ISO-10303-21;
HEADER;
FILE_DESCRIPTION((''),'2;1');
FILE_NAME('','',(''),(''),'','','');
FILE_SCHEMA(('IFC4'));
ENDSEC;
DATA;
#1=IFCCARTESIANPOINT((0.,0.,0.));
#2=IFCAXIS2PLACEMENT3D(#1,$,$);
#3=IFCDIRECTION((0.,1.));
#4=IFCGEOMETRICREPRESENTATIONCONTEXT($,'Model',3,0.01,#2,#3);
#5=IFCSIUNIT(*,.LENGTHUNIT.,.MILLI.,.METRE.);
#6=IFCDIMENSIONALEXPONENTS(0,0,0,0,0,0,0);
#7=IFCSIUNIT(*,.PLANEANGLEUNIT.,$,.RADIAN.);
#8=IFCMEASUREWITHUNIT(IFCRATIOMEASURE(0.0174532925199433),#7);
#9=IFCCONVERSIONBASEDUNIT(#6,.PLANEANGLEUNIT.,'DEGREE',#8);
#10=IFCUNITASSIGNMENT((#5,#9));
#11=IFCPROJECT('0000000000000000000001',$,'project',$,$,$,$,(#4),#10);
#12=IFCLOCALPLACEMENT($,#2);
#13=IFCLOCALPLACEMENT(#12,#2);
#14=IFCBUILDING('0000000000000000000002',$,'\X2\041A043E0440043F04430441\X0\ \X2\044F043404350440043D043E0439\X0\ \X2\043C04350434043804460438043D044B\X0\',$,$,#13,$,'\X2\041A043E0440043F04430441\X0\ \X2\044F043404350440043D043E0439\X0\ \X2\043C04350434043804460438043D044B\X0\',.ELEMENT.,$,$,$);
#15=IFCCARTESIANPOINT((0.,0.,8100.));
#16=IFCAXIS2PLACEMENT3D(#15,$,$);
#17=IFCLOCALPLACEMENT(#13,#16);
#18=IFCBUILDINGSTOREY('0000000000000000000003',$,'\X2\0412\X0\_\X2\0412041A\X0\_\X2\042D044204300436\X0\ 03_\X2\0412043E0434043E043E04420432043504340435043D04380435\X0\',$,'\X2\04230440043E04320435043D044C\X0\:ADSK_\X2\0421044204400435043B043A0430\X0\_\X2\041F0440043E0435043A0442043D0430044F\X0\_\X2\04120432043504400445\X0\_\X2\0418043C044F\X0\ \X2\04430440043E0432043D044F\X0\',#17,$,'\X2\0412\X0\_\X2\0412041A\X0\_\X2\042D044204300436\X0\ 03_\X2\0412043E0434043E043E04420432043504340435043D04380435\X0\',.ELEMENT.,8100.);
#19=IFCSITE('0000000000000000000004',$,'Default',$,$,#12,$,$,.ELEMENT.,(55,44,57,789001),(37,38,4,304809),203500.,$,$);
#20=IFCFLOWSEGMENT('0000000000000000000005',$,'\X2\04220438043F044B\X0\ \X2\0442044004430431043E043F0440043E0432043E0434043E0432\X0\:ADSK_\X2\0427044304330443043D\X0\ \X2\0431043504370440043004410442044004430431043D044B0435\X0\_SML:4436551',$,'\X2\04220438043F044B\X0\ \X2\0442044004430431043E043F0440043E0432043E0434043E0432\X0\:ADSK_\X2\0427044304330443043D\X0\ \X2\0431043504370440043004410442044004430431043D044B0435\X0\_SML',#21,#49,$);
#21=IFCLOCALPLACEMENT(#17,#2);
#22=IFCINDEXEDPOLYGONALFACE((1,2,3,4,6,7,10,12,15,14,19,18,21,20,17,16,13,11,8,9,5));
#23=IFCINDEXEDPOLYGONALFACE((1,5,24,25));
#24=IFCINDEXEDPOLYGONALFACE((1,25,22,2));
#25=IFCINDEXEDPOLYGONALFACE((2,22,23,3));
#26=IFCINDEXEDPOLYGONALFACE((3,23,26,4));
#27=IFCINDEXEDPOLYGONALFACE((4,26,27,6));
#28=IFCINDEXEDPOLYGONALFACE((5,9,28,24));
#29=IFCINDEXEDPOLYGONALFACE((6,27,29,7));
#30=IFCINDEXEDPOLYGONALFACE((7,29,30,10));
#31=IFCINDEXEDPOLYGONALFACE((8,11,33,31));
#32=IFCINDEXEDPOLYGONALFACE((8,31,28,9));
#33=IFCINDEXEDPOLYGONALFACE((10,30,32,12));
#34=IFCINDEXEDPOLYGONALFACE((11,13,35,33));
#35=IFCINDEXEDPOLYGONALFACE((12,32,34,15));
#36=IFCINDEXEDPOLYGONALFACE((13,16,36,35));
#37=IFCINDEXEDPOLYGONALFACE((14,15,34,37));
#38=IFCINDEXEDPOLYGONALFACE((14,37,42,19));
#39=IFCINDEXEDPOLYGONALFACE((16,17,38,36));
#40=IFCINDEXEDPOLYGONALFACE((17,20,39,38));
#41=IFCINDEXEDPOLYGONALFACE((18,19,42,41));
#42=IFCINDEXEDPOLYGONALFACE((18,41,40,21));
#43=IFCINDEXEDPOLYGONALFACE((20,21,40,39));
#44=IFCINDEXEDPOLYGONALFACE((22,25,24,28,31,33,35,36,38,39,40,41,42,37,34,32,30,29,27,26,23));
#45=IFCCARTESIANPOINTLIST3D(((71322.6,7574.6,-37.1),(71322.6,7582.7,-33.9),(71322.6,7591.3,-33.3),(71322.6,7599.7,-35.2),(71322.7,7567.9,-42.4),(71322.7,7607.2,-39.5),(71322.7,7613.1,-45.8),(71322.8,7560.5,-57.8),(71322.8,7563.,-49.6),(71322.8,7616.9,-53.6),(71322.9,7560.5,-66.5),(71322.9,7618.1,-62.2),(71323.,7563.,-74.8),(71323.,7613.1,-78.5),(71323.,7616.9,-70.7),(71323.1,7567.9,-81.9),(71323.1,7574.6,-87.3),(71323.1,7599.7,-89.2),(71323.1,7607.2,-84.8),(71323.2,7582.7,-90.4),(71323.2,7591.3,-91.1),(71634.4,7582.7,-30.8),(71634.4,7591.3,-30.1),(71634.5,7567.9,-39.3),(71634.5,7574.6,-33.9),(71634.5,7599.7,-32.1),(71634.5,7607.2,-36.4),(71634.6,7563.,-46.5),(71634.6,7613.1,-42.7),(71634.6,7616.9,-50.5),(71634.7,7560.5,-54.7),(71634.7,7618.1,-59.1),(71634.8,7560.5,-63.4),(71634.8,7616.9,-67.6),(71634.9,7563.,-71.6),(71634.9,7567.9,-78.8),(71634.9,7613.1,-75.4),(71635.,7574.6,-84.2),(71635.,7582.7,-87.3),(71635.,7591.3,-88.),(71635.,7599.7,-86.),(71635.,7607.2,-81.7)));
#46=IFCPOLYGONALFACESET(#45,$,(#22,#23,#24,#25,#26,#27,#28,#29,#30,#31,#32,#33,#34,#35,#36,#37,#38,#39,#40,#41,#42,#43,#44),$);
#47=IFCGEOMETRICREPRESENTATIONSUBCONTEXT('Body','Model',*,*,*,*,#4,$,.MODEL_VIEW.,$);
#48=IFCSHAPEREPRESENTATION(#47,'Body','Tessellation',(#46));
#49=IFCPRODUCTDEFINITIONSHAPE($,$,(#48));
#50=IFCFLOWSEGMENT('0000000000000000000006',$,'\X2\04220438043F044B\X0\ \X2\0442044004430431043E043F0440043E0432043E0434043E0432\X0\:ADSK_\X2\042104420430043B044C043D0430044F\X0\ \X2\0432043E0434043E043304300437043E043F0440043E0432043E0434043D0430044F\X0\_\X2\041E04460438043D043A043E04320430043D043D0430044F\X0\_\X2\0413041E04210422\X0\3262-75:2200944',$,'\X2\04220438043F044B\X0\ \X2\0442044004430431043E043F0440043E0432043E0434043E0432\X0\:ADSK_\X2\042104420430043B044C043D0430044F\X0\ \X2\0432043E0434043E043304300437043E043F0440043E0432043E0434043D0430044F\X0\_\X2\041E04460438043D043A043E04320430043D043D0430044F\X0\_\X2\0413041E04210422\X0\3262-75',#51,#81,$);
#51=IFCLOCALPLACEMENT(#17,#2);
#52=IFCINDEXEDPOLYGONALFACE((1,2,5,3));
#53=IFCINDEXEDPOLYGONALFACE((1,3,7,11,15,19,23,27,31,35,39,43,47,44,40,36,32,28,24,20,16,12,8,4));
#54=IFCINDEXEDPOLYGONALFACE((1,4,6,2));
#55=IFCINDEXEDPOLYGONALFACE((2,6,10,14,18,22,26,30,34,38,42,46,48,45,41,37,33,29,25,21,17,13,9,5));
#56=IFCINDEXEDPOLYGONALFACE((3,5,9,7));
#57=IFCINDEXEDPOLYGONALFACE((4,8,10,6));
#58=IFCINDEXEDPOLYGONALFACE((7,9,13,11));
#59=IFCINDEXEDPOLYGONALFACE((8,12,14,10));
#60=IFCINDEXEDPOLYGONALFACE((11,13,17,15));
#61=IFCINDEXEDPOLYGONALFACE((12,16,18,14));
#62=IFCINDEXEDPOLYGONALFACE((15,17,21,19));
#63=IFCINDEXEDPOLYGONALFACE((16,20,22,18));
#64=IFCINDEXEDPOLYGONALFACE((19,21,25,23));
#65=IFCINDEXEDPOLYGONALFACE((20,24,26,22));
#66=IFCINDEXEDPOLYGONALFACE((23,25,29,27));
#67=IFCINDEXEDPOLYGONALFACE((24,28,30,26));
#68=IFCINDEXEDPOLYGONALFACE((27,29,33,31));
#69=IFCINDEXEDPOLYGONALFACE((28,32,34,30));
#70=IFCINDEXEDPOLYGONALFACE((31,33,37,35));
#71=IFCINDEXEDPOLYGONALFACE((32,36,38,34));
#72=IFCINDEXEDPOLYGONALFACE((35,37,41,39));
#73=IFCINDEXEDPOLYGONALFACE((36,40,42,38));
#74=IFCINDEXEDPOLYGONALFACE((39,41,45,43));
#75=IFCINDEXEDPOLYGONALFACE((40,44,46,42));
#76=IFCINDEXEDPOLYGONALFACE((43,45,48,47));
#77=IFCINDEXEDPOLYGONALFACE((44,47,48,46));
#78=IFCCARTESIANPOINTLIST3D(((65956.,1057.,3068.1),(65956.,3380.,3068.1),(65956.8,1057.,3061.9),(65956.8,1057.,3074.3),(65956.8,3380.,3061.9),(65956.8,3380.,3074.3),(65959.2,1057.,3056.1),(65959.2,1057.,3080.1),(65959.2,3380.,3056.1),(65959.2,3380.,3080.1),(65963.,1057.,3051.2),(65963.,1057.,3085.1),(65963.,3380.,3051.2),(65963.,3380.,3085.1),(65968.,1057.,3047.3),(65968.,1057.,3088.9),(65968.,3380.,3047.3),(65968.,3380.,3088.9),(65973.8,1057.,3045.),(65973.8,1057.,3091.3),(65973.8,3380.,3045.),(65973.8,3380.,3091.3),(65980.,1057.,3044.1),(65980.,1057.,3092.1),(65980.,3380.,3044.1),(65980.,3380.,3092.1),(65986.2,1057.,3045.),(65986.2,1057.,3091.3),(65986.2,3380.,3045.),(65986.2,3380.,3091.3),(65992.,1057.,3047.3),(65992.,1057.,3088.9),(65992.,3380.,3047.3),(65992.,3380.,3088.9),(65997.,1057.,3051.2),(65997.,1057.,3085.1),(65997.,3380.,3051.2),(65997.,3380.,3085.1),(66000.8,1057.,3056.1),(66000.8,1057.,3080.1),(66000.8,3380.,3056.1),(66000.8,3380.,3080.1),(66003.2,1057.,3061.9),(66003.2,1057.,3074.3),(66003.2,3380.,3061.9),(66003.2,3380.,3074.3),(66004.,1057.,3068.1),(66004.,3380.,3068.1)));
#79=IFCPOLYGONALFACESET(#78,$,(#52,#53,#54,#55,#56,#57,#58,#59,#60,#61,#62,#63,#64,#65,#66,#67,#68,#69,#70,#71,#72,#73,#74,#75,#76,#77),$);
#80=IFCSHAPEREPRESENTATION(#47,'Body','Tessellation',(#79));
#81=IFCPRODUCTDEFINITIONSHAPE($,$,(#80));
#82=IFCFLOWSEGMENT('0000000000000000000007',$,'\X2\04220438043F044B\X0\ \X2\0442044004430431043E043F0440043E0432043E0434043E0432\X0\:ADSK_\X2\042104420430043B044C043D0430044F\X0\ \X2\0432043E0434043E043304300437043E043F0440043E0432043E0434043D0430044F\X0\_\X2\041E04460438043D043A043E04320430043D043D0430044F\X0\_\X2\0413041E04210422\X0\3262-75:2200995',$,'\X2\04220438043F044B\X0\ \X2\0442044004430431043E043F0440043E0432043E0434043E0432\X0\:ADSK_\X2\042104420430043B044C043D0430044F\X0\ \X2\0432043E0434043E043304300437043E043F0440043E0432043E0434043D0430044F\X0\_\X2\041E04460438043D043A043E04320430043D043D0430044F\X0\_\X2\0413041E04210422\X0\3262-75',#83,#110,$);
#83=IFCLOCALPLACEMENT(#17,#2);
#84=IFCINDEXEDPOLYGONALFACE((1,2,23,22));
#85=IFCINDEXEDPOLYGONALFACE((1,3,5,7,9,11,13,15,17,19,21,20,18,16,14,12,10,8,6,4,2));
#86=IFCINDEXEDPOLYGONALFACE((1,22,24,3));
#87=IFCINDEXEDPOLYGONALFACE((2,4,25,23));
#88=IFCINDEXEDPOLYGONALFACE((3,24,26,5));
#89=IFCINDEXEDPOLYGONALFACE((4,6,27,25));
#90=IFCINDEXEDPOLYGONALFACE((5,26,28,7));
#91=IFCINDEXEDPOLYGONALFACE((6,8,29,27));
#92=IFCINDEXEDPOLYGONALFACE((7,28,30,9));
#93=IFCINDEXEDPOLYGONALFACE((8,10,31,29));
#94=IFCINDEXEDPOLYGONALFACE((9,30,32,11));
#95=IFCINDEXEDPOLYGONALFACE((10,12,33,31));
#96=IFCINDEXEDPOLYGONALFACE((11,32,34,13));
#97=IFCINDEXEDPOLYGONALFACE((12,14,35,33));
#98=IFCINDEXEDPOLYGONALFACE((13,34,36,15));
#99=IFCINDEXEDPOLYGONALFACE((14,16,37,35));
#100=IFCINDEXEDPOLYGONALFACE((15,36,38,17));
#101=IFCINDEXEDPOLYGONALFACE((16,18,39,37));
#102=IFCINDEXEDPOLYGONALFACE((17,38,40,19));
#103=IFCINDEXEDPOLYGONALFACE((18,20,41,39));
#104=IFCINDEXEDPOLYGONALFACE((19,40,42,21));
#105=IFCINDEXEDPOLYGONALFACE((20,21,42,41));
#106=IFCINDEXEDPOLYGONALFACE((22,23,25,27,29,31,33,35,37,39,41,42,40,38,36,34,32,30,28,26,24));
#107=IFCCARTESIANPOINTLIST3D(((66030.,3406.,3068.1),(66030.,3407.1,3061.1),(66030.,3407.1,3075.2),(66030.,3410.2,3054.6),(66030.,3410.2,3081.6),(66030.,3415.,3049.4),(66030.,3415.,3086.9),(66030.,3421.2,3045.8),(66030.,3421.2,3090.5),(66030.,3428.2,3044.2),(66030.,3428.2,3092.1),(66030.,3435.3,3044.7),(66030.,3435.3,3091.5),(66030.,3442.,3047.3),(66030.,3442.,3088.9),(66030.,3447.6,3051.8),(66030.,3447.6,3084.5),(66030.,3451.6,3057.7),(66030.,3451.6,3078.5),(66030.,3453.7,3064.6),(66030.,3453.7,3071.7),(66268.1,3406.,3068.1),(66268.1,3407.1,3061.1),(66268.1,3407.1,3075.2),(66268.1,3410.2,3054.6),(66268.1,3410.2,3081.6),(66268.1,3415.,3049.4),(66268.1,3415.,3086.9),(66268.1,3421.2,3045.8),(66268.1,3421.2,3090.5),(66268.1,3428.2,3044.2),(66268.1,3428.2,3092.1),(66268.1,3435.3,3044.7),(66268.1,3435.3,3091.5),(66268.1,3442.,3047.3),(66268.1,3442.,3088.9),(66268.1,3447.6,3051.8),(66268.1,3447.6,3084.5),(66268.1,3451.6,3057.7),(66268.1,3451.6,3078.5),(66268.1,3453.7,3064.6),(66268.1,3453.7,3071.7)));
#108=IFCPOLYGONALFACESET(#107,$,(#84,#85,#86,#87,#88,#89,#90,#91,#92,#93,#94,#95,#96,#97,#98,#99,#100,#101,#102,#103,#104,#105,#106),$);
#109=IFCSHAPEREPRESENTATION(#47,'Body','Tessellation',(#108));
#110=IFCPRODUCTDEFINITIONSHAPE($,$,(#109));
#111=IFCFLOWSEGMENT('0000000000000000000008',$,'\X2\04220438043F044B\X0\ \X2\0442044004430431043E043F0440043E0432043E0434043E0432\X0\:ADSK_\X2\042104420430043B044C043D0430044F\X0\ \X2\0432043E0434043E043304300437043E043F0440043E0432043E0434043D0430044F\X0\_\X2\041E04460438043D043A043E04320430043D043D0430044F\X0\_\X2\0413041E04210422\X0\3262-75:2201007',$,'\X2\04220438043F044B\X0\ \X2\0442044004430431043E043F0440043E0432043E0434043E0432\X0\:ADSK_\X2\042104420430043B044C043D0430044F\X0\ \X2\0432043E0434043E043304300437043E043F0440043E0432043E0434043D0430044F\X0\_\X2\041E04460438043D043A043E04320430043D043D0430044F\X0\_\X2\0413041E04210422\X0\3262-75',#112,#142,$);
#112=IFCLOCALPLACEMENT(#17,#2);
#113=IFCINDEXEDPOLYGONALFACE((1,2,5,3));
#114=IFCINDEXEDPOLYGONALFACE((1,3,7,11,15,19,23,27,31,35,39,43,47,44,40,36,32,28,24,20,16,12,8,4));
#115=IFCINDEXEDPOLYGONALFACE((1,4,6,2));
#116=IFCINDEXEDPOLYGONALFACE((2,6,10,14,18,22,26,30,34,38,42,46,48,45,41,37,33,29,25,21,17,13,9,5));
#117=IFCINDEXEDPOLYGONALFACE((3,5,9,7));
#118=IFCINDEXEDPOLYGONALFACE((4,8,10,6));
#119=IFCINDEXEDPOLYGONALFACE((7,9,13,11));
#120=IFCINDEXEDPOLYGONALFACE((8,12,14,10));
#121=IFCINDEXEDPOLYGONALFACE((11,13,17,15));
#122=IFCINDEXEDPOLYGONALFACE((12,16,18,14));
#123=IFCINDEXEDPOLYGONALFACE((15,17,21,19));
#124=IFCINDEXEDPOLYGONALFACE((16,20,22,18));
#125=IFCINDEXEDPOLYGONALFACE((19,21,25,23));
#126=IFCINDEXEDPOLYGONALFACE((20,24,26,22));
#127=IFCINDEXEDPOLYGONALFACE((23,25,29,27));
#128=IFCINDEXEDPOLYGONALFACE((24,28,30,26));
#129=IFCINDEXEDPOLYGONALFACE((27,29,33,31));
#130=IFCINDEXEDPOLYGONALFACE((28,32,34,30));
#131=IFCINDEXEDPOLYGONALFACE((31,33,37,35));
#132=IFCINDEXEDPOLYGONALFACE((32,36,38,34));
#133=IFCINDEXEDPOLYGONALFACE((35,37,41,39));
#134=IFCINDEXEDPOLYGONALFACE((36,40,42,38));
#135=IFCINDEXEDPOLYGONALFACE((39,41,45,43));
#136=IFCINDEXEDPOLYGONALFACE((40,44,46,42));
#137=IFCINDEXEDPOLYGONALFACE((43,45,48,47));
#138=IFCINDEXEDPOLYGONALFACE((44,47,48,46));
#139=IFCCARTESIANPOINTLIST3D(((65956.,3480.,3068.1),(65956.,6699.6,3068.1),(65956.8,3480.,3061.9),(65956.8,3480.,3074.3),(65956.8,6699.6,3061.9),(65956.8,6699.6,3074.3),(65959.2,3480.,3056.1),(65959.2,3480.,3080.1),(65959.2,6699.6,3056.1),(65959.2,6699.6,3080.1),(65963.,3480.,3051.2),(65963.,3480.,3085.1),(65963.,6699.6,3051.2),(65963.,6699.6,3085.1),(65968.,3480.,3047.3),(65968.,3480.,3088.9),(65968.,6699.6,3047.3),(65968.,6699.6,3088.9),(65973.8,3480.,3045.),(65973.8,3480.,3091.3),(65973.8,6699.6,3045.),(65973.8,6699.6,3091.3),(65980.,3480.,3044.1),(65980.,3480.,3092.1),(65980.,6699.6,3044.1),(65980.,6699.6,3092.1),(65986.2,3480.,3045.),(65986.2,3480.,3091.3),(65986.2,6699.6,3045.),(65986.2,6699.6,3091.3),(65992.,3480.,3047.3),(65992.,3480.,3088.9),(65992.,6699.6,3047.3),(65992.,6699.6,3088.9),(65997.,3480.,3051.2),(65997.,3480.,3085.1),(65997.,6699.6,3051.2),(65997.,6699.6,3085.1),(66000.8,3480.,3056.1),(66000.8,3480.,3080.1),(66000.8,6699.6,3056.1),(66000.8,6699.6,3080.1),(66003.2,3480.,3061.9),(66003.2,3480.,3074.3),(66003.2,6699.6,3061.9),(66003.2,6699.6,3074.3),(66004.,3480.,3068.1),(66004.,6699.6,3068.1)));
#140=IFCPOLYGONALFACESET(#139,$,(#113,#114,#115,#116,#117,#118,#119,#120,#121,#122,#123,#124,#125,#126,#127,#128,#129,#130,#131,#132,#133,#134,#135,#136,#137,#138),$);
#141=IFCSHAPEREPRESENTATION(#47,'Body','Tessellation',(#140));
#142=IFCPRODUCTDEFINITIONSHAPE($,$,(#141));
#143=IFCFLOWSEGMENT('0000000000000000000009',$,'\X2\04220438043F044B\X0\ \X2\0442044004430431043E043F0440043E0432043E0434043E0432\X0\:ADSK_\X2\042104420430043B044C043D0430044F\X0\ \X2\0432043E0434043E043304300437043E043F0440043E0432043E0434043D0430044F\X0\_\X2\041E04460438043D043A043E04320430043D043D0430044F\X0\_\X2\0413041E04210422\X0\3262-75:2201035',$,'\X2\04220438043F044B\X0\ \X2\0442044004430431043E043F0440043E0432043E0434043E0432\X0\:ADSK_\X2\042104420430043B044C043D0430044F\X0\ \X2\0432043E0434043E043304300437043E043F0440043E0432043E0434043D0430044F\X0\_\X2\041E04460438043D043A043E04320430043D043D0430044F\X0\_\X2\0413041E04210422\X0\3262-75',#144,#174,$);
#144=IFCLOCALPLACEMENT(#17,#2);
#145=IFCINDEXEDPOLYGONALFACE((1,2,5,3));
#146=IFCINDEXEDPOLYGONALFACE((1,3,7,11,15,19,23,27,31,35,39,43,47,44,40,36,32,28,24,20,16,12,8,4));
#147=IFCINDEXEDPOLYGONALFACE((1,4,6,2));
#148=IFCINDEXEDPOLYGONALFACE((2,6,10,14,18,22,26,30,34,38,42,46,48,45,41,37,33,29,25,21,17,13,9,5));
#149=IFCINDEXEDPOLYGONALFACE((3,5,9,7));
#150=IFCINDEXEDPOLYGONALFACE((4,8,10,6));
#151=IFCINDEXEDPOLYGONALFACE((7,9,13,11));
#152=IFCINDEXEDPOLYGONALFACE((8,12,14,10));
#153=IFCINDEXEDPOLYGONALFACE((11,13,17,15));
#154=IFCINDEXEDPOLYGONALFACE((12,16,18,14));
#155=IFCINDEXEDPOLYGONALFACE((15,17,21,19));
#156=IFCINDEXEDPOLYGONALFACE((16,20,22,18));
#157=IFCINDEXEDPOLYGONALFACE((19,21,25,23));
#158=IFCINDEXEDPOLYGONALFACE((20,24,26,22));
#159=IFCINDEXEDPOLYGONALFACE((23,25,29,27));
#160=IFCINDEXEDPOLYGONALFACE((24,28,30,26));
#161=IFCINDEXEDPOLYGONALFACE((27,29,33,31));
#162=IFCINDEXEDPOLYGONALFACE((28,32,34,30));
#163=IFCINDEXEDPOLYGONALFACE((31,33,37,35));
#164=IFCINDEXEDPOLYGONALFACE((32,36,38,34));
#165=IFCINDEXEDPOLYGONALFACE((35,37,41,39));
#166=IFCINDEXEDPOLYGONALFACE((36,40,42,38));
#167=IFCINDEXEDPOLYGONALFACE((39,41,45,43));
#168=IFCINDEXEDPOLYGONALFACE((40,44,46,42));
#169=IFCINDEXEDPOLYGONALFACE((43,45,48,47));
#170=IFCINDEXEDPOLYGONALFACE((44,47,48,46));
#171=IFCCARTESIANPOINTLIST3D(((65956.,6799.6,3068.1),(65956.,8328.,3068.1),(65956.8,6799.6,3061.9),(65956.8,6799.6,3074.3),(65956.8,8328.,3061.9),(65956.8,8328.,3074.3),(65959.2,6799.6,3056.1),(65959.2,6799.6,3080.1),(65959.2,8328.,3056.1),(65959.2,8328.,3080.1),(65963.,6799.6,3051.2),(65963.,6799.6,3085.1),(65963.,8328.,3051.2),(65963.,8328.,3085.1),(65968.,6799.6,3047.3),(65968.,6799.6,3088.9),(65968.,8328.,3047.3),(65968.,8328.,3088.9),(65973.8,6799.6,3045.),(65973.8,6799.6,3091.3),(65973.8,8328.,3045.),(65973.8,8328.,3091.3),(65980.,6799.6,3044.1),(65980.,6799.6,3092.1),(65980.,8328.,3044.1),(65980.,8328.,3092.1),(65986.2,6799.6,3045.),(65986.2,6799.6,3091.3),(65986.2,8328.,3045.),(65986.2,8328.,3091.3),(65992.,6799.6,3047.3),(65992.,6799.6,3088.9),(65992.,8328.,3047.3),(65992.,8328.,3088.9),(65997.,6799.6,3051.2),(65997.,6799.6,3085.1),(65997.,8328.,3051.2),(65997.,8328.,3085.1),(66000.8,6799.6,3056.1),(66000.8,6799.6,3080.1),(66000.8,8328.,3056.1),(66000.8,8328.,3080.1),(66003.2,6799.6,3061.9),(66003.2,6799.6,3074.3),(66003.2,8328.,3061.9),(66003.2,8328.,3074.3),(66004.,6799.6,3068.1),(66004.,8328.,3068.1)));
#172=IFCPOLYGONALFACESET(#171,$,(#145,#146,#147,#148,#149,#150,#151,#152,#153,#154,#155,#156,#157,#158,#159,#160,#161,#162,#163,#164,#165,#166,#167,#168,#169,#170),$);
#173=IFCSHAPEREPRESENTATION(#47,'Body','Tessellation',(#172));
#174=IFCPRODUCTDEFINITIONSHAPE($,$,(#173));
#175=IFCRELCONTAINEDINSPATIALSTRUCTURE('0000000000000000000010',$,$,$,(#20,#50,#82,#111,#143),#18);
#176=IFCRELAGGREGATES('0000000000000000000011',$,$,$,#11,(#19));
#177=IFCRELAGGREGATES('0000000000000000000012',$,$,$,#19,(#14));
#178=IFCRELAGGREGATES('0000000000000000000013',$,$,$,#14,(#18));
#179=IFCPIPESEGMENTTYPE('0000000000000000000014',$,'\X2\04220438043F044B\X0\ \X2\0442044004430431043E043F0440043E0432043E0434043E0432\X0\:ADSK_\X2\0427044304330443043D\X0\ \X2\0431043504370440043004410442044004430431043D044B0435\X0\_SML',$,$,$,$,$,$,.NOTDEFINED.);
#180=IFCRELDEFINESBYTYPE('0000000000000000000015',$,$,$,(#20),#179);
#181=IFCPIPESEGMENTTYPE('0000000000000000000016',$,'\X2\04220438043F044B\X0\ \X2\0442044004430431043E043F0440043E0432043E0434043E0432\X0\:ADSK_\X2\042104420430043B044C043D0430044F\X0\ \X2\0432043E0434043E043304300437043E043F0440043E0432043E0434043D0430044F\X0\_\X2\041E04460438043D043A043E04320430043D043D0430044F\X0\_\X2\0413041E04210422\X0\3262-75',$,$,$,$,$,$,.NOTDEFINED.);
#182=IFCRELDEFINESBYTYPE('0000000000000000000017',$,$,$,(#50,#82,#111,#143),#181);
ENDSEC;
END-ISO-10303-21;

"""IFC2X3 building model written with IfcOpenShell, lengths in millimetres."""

from ifc_helpers import new_model, entity, si_unit, converted_unit, direction, frame, origin, origin_2d_with_axis, place, context, subcontext, project, spatial, polyline, circle, outline, extrude, type_object, element, save


model = new_model("IFC2X3")

# Units and contexts
model_context = context("Model", 3, precision=0.01, world=origin(), true_north=direction((0.0, 1.0)))
body_context = subcontext(model_context, "Body", "Model", "MODEL_VIEW")
ifc_project = project(units=[si_unit("LENGTHUNIT", "METRE", prefix="MILLI"), converted_unit("PLANEANGLEUNIT", "DEGREE", entity("IfcRatioMeasure", 0.0174532925199433), si_unit("PLANEANGLEUNIT", "RADIAN"), dimensions=[0, 0, 0, 0, 0, 0, 0])], contexts=[model_context])

# Site, building, storey
site_placement = place(None, origin())
site = spatial("IfcSite", under=ifc_project, at=site_placement, Name="Default", CompositionType="ELEMENT", RefLatitude=(55, 44, 57, 789001), RefLongitude=(37, 38, 4, 304809), RefElevation=203500.0)
building_placement = place(site_placement, origin())
building = spatial("IfcBuilding", under=site, at=building_placement, Name="Корпус ядерной медицины", LongName="Корпус ядерной медицины", CompositionType="ELEMENT")
storey_placement = place(building_placement, frame((0.0, 0.0, 8100.0)))
storey = spatial("IfcBuildingStorey", under=building, at=storey_placement, Name="В_ВК_Этаж 03_Водоотведение", ObjectType="Уровень:ADSK_Стрелка_Проектная_Вверх_Имя уровня", LongName="В_ВК_Этаж 03_Водоотведение", CompositionType="ELEMENT", Elevation=8100.0)

# Flow segments
pipe_segment_type_1 = type_object("IfcPipeSegmentType", Name="Типы трубопроводов:ADSK_Чугун безраструбные_SML", PredefinedType="NOTDEFINED")
flow_segment_1_placement = place(storey_placement, frame((71321.0, 7558.5, -92.8)))
element("IfcFlowSegment", 1, at=flow_segment_1_placement, inside=storey, type_object=pipe_segment_type_1, Name="Типы трубопроводов:ADSK_Чугун безраструбные_SML:4436551", ObjectType="Типы трубопроводов:ADSK_Чугун безраструбные_SML", context=body_context, shape_type="SweptSolid", body=[
    extrude(circle(Radius=29.0, at=origin_2d_with_axis()), frame((1.9, 30.6, 30.6), z_axis=(0.99995, 0.000005, 0.01), x_axis=(-0.000005, 1.0, 0.0)), (0.0, 0.0, 1.0), 311.9),
])
pipe_segment_type_2 = type_object("IfcPipeSegmentType", Name="Типы трубопроводов:ADSK_Стальная водогазопроводная_Оцинкованная_ГОСТ3262-75", PredefinedType="NOTDEFINED")
flow_segment_2_placement = place(storey_placement, frame((65954.4, 1057.0, 3042.5)))
element("IfcFlowSegment", 2, at=flow_segment_2_placement, inside=storey, type_object=pipe_segment_type_2, Name="Типы трубопроводов:ADSK_Стальная водогазопроводная_Оцинкованная_ГОСТ3262-75:2200944", ObjectType="Типы трубопроводов:ADSK_Стальная водогазопроводная_Оцинкованная_ГОСТ3262-75", context=body_context, shape_type="SweptSolid", body=[
    extrude(outline(polyline([(-3.1, -23.8), (3.1, -23.8), (9.2, -22.2), (14.6, -19.0), (19.0, -14.6), (22.2, -9.2), (23.8, -3.1), (23.8, 3.1), (22.2, 9.2), (19.0, 14.6), (14.6, 19.0), (9.2, 22.2), (3.1, 23.8), (-3.1, 23.8), (-9.2, 22.2), (-14.6, 19.0), (-19.0, 14.6), (-22.2, 9.2), (-23.8, 3.1), (-23.8, -3.1), (-22.2, -9.2), (-19.0, -14.6), (-14.6, -19.0), (-9.2, -22.2), (-3.1, -23.8)])), frame((25.6, 0.0, 25.6), z_axis=(0.0, 1.0, 0.0), x_axis=(0.130526, 0.0, 0.991445)), (0.0, 0.0, 1.0), 2323.0),
])
flow_segment_3_placement = place(storey_placement, frame((66030.0, 3404.4, 3042.5)))
element("IfcFlowSegment", 3, at=flow_segment_3_placement, inside=storey, type_object=pipe_segment_type_2, Name="Типы трубопроводов:ADSK_Стальная водогазопроводная_Оцинкованная_ГОСТ3262-75:2200995", ObjectType="Типы трубопроводов:ADSK_Стальная водогазопроводная_Оцинкованная_ГОСТ3262-75", context=body_context, shape_type="SweptSolid", body=[
    extrude(circle(Radius=24.0, at=origin_2d_with_axis()), frame((0.0, 25.6, 25.6), z_axis=(1.0, 0.000003, 0.0), x_axis=(0.000003, -1.0, 0.0)), (0.0, 0.0, 1.0), 238.1),
])
flow_segment_4_placement = place(storey_placement, frame((65954.4, 3480.0, 3042.5)))
element("IfcFlowSegment", 4, at=flow_segment_4_placement, inside=storey, type_object=pipe_segment_type_2, Name="Типы трубопроводов:ADSK_Стальная водогазопроводная_Оцинкованная_ГОСТ3262-75:2201007", ObjectType="Типы трубопроводов:ADSK_Стальная водогазопроводная_Оцинкованная_ГОСТ3262-75", context=body_context, shape_type="SweptSolid", body=[
    extrude(outline(polyline([(-3.1, -23.8), (3.1, -23.8), (9.2, -22.2), (14.6, -19.0), (19.0, -14.6), (22.2, -9.2), (23.8, -3.1), (23.8, 3.1), (22.2, 9.2), (19.0, 14.6), (14.6, 19.0), (9.2, 22.2), (3.1, 23.8), (-3.1, 23.8), (-9.2, 22.2), (-14.6, 19.0), (-19.0, 14.6), (-22.2, 9.2), (-23.8, 3.1), (-23.8, -3.1), (-22.2, -9.2), (-19.0, -14.6), (-14.6, -19.0), (-9.2, -22.2), (-3.1, -23.8)])), frame((25.6, 0.0, 25.6), z_axis=(0.0, 1.0, 0.0), x_axis=(0.130526, 0.0, 0.991445)), (0.0, 0.0, 1.0), 3219.6),
])
flow_segment_5_placement = place(storey_placement, frame((65954.4, 6799.6, 3042.5)))
element("IfcFlowSegment", 5, at=flow_segment_5_placement, inside=storey, type_object=pipe_segment_type_2, Name="Типы трубопроводов:ADSK_Стальная водогазопроводная_Оцинкованная_ГОСТ3262-75:2201035", ObjectType="Типы трубопроводов:ADSK_Стальная водогазопроводная_Оцинкованная_ГОСТ3262-75", context=body_context, shape_type="SweptSolid", body=[
    extrude(outline(polyline([(-3.1, -23.8), (3.1, -23.8), (9.2, -22.2), (14.6, -19.0), (19.0, -14.6), (22.2, -9.2), (23.8, -3.1), (23.8, 3.1), (22.2, 9.2), (19.0, 14.6), (14.6, 19.0), (9.2, 22.2), (3.1, 23.8), (-3.1, 23.8), (-9.2, 22.2), (-14.6, 19.0), (-19.0, 14.6), (-22.2, 9.2), (-23.8, 3.1), (-23.8, -3.1), (-22.2, -9.2), (-19.0, -14.6), (-14.6, -19.0), (-9.2, -22.2), (-3.1, -23.8)])), frame((25.6, 0.0, 25.6), z_axis=(0.0, 1.0, 0.0), x_axis=(0.130526, 0.0, 0.991445)), (0.0, 0.0, 1.0), 1528.4),
])

save(model, "model.ifc")
